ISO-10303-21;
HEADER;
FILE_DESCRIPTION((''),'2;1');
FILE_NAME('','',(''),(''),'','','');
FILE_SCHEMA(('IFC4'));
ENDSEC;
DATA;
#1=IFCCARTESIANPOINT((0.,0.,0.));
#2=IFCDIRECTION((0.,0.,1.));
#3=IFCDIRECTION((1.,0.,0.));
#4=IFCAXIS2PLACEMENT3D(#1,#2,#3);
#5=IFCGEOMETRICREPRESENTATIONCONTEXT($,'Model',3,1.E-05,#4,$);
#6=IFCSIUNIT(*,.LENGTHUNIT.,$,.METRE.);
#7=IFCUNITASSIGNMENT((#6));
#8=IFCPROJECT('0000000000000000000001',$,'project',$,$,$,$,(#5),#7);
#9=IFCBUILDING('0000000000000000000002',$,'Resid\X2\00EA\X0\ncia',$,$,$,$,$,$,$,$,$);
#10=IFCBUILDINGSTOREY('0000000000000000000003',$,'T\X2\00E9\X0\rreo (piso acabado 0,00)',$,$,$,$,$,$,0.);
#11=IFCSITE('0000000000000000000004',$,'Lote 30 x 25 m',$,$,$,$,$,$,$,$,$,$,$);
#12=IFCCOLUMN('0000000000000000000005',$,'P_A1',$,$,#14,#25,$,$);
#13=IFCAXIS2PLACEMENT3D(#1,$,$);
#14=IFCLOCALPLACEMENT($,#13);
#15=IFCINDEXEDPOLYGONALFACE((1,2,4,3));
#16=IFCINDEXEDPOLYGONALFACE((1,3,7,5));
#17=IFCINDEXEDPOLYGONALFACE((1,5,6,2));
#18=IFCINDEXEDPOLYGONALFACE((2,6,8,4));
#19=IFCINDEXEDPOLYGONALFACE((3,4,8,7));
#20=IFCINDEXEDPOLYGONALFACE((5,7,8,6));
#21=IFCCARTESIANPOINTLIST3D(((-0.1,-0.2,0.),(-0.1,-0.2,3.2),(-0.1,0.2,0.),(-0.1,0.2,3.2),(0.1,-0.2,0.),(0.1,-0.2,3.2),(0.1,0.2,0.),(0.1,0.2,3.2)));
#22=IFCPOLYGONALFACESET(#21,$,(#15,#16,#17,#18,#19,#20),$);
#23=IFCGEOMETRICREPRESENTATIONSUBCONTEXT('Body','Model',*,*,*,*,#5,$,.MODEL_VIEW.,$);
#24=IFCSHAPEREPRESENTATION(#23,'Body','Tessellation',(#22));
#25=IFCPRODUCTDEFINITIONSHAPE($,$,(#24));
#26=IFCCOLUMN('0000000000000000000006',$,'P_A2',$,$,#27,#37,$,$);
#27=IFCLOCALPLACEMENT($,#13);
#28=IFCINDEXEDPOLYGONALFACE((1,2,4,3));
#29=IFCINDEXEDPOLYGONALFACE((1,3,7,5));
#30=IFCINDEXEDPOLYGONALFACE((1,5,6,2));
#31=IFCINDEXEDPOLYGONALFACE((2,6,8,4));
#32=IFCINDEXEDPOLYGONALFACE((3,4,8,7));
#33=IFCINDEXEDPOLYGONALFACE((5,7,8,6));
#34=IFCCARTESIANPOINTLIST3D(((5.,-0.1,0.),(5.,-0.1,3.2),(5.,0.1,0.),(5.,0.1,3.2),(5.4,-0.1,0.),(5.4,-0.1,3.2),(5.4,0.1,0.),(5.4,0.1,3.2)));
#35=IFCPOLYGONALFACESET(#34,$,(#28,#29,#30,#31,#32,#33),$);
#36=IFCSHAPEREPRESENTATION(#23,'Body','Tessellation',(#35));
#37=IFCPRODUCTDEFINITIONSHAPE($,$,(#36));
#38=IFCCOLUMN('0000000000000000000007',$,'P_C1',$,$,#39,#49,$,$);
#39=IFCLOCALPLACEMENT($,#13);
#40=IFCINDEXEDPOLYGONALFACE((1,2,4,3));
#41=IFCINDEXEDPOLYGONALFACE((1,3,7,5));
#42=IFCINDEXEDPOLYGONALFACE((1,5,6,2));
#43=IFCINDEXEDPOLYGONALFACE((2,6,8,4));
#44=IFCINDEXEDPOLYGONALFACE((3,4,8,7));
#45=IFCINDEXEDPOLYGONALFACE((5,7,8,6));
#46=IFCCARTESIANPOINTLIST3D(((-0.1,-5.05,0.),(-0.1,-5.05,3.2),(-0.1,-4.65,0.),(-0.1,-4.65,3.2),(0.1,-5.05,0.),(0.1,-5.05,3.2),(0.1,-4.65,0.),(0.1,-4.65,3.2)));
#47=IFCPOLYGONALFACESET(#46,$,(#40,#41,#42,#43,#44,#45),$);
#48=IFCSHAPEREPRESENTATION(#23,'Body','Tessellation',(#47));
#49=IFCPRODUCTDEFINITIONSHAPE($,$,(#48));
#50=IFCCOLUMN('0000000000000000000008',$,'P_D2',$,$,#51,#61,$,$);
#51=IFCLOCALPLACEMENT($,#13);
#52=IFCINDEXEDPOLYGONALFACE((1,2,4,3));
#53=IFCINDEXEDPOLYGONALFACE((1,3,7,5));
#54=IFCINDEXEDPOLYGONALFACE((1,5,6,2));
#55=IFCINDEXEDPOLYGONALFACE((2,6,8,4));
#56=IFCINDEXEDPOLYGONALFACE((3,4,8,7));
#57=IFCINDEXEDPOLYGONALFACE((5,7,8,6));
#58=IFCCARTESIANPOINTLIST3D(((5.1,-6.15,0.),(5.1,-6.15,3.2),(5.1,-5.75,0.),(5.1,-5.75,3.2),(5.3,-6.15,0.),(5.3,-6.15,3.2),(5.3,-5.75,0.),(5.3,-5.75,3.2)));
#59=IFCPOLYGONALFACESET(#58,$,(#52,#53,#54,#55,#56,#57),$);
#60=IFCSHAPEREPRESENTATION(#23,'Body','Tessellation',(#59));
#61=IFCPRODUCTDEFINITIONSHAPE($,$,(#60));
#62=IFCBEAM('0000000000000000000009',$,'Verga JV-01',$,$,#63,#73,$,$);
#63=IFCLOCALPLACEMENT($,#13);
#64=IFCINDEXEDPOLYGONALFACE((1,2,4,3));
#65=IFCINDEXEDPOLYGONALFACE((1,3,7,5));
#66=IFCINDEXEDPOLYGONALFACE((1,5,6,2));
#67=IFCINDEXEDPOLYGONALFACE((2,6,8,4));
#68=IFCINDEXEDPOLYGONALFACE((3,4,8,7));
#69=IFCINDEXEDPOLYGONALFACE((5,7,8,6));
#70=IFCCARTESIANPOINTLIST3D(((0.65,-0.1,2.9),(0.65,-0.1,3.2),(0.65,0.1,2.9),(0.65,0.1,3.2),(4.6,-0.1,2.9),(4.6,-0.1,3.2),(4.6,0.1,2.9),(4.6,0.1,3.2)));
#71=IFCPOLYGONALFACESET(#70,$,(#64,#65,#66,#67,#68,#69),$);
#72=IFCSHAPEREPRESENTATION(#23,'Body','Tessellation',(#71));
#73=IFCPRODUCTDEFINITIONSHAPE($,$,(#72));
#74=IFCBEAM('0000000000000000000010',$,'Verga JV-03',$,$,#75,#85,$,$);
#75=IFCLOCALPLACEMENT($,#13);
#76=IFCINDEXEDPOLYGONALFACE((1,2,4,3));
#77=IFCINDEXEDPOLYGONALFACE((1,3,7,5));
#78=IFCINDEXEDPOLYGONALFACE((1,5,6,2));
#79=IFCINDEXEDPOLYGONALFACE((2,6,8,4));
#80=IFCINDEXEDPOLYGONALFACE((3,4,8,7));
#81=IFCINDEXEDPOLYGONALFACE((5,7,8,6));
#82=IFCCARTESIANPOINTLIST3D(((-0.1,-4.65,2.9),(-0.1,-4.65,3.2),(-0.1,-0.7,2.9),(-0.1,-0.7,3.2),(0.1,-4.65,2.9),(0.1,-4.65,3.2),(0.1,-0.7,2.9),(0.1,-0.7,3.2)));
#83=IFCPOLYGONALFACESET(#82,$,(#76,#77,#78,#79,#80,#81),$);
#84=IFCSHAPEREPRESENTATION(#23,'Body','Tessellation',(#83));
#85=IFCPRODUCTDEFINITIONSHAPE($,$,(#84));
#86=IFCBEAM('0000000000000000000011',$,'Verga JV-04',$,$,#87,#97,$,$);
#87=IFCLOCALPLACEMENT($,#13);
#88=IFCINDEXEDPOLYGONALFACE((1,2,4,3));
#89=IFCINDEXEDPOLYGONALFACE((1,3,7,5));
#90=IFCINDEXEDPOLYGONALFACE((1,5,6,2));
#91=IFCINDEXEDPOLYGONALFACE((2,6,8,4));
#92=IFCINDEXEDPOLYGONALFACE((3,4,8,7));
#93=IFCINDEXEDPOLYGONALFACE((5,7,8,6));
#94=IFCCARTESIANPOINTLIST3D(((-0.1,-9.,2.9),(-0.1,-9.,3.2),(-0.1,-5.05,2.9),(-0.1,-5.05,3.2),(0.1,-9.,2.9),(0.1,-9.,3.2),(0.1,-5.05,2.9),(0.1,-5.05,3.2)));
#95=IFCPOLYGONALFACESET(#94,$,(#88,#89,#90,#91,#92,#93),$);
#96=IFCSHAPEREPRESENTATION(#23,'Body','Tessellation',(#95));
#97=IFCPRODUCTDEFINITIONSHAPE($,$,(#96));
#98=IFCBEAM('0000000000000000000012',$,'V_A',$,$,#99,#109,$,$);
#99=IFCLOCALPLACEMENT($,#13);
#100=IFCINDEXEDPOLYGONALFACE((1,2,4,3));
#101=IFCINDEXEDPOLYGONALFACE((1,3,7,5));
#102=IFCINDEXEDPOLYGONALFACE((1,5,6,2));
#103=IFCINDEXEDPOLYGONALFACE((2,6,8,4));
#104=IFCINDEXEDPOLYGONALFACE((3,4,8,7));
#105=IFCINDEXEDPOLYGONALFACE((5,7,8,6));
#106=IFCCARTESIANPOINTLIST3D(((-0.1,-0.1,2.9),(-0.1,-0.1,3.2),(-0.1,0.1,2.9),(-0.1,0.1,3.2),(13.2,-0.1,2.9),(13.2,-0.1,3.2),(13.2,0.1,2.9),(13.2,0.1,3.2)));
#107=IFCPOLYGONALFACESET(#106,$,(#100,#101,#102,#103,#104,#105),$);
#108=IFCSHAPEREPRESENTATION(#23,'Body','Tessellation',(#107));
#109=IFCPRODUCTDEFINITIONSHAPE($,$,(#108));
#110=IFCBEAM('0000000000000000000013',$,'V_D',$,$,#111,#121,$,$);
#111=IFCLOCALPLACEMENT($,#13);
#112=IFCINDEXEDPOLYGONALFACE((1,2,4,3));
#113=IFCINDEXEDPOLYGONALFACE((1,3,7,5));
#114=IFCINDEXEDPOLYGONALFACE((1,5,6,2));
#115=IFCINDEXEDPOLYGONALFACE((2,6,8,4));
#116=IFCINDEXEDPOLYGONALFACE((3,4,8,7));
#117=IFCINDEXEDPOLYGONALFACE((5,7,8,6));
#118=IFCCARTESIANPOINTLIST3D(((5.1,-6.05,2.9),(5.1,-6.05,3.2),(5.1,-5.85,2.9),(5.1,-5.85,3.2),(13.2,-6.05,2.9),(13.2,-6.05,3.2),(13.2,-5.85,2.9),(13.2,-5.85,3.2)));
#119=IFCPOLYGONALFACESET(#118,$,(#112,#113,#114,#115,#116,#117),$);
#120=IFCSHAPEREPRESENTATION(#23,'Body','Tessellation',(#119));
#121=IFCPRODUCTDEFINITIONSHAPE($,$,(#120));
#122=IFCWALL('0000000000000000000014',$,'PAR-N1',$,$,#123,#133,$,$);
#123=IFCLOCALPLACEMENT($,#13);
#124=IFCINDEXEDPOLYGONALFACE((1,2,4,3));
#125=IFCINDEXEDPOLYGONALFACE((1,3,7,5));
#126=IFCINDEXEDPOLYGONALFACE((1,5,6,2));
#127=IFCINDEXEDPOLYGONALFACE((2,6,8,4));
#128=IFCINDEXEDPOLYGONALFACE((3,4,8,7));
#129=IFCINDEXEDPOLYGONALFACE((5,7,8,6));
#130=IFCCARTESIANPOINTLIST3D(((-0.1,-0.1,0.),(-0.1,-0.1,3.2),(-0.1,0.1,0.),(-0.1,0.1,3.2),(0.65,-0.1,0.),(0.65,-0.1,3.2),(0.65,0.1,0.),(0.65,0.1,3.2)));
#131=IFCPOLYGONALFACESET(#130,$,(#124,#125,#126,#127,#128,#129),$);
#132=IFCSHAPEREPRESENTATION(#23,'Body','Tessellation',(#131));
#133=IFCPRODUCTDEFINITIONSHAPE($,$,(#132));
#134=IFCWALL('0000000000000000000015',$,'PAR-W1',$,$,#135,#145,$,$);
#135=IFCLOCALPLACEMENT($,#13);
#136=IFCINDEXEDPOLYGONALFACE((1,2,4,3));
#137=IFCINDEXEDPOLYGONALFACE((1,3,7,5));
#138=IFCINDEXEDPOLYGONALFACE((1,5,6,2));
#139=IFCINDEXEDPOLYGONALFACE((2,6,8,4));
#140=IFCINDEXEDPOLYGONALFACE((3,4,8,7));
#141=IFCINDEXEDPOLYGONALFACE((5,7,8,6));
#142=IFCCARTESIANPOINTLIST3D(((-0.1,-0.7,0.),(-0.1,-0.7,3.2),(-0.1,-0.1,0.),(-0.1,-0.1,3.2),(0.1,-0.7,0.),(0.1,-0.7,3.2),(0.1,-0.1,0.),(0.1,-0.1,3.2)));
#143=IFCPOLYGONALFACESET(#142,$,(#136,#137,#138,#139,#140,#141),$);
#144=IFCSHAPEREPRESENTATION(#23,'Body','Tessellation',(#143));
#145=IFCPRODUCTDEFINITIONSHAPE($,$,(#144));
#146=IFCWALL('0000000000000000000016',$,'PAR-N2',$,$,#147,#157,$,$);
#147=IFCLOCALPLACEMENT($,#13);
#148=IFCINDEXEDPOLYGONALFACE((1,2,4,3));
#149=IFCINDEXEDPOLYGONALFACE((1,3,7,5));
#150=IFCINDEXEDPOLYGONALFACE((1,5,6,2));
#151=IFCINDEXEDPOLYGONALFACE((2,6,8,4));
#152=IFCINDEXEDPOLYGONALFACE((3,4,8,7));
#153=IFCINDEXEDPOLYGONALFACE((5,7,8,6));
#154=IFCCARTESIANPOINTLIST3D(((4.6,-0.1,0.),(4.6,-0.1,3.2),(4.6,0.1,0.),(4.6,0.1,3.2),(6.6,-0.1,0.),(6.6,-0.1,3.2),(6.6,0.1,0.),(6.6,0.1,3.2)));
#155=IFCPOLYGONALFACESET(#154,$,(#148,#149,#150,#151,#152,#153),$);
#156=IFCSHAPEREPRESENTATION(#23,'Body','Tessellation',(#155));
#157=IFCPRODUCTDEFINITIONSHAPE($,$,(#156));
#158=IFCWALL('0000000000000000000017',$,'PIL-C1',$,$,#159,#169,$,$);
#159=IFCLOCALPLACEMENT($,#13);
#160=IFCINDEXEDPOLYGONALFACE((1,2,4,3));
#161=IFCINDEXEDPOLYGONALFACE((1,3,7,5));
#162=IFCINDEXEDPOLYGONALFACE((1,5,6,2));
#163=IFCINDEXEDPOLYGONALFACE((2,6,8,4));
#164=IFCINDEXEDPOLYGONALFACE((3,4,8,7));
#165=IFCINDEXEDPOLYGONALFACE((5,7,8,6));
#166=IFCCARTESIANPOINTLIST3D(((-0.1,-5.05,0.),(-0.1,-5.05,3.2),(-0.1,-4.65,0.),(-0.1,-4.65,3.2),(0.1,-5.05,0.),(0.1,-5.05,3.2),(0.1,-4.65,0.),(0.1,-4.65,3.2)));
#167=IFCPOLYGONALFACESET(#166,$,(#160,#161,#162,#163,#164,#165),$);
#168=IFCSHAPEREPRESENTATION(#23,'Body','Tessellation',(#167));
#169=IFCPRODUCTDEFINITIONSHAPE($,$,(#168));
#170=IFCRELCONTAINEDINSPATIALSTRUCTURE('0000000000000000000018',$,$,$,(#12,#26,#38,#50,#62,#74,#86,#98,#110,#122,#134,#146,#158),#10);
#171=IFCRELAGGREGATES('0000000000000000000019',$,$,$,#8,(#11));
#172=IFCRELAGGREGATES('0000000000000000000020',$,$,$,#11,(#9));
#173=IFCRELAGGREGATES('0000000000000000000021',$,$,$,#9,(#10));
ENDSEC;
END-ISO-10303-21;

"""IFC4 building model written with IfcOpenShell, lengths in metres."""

from ifc_helpers import new_model, si_unit, frame, origin_with_axes, place, context, subcontext, project, spatial, line, indexed_curve, outline, extrude, element, save


model = new_model("IFC4")

# Units and contexts
model_context = context("Model", 3, precision=1e-05, world=origin_with_axes())
body_context = subcontext(model_context, "Body", "Model", "MODEL_VIEW")
ifc_project = project(units=[si_unit("LENGTHUNIT", "METRE")], contexts=[model_context])

# Site, building, storey
site = spatial("IfcSite", under=ifc_project, Name="Lote 30 x 25 m")
building = spatial("IfcBuilding", under=site, Name="Residência")
storey = spatial("IfcBuildingStorey", under=building, Name="Térreo (piso acabado 0,00)", Elevation=0.0)

# Columns
column_1_placement = place(None, frame((-0.1, -0.2, 0.0), z_axis=(0.0, 0.0, 1.0), x_axis=(1.0, 0.0, 0.0)))
element("IfcColumn", 1, at=column_1_placement, inside=storey, Name="P_A1", context=body_context, shape_type="SweptSolid", body=[
    extrude(outline(indexed_curve([(0.0, 0.0), (0.2, 0.0), (0.2, 0.4), (0.0, 0.4)], segments=[line(1, 2, 3, 4, 1)])), origin_with_axes(), (0.0, 0.0, 1.0), 3.2),
])
column_2_placement = place(None, frame((5.0, -0.1, 0.0), z_axis=(0.0, 0.0, 1.0), x_axis=(1.0, 0.0, 0.0)))
element("IfcColumn", 2, at=column_2_placement, inside=storey, Name="P_A2", context=body_context, shape_type="SweptSolid", body=[
    extrude(outline(indexed_curve([(0.0, 0.0), (0.4, 0.0), (0.4, 0.2), (0.0, 0.2)], segments=[line(1, 2, 3, 4, 1)])), origin_with_axes(), (0.0, 0.0, 1.0), 3.2),
])
column_3_placement = place(None, frame((-0.1, -5.05, 0.0), z_axis=(0.0, 0.0, 1.0), x_axis=(1.0, 0.0, 0.0)))
element("IfcColumn", 3, at=column_3_placement, inside=storey, Name="P_C1", context=body_context, shape_type="SweptSolid", body=[
    extrude(outline(indexed_curve([(0.0, 0.0), (0.2, 0.0), (0.2, 0.4), (0.0, 0.4)], segments=[line(1, 2, 3, 4, 1)])), origin_with_axes(), (0.0, 0.0, 1.0), 3.2),
])
column_4_placement = place(None, frame((5.1, -6.15, 0.0), z_axis=(0.0, 0.0, 1.0), x_axis=(1.0, 0.0, 0.0)))
element("IfcColumn", 4, at=column_4_placement, inside=storey, Name="P_D2", context=body_context, shape_type="SweptSolid", body=[
    extrude(outline(indexed_curve([(0.0, 0.0), (0.2, 0.0), (0.2, 0.4), (0.0, 0.4)], segments=[line(1, 2, 3, 4, 1)])), origin_with_axes(), (0.0, 0.0, 1.0), 3.2),
])

# Beams
beam_1_placement = place(None, frame((0.65, -0.1, 2.9), z_axis=(0.0, 0.0, 1.0), x_axis=(1.0, 0.0, 0.0)))
element("IfcBeam", 5, at=beam_1_placement, inside=storey, Name="Verga JV-01", context=body_context, shape_type="SweptSolid", body=[
    extrude(outline(indexed_curve([(0.0, 0.0), (3.95, 0.0), (3.95, 0.2), (0.0, 0.2)], segments=[line(1, 2, 3, 4, 1)])), origin_with_axes(), (0.0, 0.0, 1.0), 0.3),
])
for number, where, z_axis, x_axis, name in (
    (6, (-0.1, -4.65, 2.9), (0.0, 0.0, 1.0), (1.0, 0.0, 0.0), "Verga JV-03"),
    (7, (-0.1, -9.0, 2.9), (0.0, 0.0, 1.0), (1.0, 0.0, 0.0), "Verga JV-04"),
):
    element("IfcBeam", number, at=place(None, frame(where, z_axis=z_axis, x_axis=x_axis)), inside=storey, Name=name, context=body_context, shape_type="SweptSolid", body=[
        extrude(outline(indexed_curve([(0.0, 0.0), (0.2, 0.0), (0.2, 3.95), (0.0, 3.95)], segments=[line(1, 2, 3, 4, 1)])), origin_with_axes(), (0.0, 0.0, 1.0), 0.3),
    ])
beam_2_placement = place(None, frame((-0.1, -0.1, 2.9), z_axis=(0.0, 0.0, 1.0), x_axis=(1.0, 0.0, 0.0)))
element("IfcBeam", 8, at=beam_2_placement, inside=storey, Name="V_A", context=body_context, shape_type="SweptSolid", body=[
    extrude(outline(indexed_curve([(0.0, 0.0), (13.3, 0.0), (13.3, 0.2), (0.0, 0.2)], segments=[line(1, 2, 3, 4, 1)])), origin_with_axes(), (0.0, 0.0, 1.0), 0.3),
])
beam_3_placement = place(None, frame((5.1, -6.05, 2.9), z_axis=(0.0, 0.0, 1.0), x_axis=(1.0, 0.0, 0.0)))
element("IfcBeam", 9, at=beam_3_placement, inside=storey, Name="V_D", context=body_context, shape_type="SweptSolid", body=[
    extrude(outline(indexed_curve([(0.0, 0.0), (8.1, 0.0), (8.1, 0.2), (0.0, 0.2)], segments=[line(1, 2, 3, 4, 1)])), origin_with_axes(), (0.0, 0.0, 1.0), 0.3),
])

# Walls
wall_1_placement = place(None, frame((-0.1, -0.1, 0.0), z_axis=(0.0, 0.0, 1.0), x_axis=(1.0, 0.0, 0.0)))
element("IfcWall", 10, at=wall_1_placement, inside=storey, Name="PAR-N1", context=body_context, shape_type="SweptSolid", body=[
    extrude(outline(indexed_curve([(0.0, 0.0), (0.75, 0.0), (0.75, 0.2), (0.0, 0.2)], segments=[line(1, 2, 3, 4, 1)])), origin_with_axes(), (0.0, 0.0, 1.0), 3.2),
])
wall_2_placement = place(None, frame((-0.1, -0.7, 0.0), z_axis=(0.0, 0.0, 1.0), x_axis=(1.0, 0.0, 0.0)))
element("IfcWall", 11, at=wall_2_placement, inside=storey, Name="PAR-W1", context=body_context, shape_type="SweptSolid", body=[
    extrude(outline(indexed_curve([(0.0, 0.0), (0.2, 0.0), (0.2, 0.6), (0.0, 0.6)], segments=[line(1, 2, 3, 4, 1)])), origin_with_axes(), (0.0, 0.0, 1.0), 3.2),
])
wall_3_placement = place(None, frame((4.6, -0.1, 0.0), z_axis=(0.0, 0.0, 1.0), x_axis=(1.0, 0.0, 0.0)))
element("IfcWall", 12, at=wall_3_placement, inside=storey, Name="PAR-N2", context=body_context, shape_type="SweptSolid", body=[
    extrude(outline(indexed_curve([(0.0, 0.0), (2.0, 0.0), (2.0, 0.2), (0.0, 0.2)], segments=[line(1, 2, 3, 4, 1)])), origin_with_axes(), (0.0, 0.0, 1.0), 3.2),
])
wall_4_placement = place(None, frame((-0.1, -5.05, 0.0), z_axis=(0.0, 0.0, 1.0), x_axis=(1.0, 0.0, 0.0)))
element("IfcWall", 13, at=wall_4_placement, inside=storey, Name="PIL-C1", context=body_context, shape_type="SweptSolid", body=[
    extrude(outline(indexed_curve([(0.0, 0.0), (0.2, 0.0), (0.2, 0.4), (0.0, 0.4)], segments=[line(1, 2, 3, 4, 1)])), origin_with_axes(), (0.0, 0.0, 1.0), 3.2),
])

save(model, "model.ifc")
